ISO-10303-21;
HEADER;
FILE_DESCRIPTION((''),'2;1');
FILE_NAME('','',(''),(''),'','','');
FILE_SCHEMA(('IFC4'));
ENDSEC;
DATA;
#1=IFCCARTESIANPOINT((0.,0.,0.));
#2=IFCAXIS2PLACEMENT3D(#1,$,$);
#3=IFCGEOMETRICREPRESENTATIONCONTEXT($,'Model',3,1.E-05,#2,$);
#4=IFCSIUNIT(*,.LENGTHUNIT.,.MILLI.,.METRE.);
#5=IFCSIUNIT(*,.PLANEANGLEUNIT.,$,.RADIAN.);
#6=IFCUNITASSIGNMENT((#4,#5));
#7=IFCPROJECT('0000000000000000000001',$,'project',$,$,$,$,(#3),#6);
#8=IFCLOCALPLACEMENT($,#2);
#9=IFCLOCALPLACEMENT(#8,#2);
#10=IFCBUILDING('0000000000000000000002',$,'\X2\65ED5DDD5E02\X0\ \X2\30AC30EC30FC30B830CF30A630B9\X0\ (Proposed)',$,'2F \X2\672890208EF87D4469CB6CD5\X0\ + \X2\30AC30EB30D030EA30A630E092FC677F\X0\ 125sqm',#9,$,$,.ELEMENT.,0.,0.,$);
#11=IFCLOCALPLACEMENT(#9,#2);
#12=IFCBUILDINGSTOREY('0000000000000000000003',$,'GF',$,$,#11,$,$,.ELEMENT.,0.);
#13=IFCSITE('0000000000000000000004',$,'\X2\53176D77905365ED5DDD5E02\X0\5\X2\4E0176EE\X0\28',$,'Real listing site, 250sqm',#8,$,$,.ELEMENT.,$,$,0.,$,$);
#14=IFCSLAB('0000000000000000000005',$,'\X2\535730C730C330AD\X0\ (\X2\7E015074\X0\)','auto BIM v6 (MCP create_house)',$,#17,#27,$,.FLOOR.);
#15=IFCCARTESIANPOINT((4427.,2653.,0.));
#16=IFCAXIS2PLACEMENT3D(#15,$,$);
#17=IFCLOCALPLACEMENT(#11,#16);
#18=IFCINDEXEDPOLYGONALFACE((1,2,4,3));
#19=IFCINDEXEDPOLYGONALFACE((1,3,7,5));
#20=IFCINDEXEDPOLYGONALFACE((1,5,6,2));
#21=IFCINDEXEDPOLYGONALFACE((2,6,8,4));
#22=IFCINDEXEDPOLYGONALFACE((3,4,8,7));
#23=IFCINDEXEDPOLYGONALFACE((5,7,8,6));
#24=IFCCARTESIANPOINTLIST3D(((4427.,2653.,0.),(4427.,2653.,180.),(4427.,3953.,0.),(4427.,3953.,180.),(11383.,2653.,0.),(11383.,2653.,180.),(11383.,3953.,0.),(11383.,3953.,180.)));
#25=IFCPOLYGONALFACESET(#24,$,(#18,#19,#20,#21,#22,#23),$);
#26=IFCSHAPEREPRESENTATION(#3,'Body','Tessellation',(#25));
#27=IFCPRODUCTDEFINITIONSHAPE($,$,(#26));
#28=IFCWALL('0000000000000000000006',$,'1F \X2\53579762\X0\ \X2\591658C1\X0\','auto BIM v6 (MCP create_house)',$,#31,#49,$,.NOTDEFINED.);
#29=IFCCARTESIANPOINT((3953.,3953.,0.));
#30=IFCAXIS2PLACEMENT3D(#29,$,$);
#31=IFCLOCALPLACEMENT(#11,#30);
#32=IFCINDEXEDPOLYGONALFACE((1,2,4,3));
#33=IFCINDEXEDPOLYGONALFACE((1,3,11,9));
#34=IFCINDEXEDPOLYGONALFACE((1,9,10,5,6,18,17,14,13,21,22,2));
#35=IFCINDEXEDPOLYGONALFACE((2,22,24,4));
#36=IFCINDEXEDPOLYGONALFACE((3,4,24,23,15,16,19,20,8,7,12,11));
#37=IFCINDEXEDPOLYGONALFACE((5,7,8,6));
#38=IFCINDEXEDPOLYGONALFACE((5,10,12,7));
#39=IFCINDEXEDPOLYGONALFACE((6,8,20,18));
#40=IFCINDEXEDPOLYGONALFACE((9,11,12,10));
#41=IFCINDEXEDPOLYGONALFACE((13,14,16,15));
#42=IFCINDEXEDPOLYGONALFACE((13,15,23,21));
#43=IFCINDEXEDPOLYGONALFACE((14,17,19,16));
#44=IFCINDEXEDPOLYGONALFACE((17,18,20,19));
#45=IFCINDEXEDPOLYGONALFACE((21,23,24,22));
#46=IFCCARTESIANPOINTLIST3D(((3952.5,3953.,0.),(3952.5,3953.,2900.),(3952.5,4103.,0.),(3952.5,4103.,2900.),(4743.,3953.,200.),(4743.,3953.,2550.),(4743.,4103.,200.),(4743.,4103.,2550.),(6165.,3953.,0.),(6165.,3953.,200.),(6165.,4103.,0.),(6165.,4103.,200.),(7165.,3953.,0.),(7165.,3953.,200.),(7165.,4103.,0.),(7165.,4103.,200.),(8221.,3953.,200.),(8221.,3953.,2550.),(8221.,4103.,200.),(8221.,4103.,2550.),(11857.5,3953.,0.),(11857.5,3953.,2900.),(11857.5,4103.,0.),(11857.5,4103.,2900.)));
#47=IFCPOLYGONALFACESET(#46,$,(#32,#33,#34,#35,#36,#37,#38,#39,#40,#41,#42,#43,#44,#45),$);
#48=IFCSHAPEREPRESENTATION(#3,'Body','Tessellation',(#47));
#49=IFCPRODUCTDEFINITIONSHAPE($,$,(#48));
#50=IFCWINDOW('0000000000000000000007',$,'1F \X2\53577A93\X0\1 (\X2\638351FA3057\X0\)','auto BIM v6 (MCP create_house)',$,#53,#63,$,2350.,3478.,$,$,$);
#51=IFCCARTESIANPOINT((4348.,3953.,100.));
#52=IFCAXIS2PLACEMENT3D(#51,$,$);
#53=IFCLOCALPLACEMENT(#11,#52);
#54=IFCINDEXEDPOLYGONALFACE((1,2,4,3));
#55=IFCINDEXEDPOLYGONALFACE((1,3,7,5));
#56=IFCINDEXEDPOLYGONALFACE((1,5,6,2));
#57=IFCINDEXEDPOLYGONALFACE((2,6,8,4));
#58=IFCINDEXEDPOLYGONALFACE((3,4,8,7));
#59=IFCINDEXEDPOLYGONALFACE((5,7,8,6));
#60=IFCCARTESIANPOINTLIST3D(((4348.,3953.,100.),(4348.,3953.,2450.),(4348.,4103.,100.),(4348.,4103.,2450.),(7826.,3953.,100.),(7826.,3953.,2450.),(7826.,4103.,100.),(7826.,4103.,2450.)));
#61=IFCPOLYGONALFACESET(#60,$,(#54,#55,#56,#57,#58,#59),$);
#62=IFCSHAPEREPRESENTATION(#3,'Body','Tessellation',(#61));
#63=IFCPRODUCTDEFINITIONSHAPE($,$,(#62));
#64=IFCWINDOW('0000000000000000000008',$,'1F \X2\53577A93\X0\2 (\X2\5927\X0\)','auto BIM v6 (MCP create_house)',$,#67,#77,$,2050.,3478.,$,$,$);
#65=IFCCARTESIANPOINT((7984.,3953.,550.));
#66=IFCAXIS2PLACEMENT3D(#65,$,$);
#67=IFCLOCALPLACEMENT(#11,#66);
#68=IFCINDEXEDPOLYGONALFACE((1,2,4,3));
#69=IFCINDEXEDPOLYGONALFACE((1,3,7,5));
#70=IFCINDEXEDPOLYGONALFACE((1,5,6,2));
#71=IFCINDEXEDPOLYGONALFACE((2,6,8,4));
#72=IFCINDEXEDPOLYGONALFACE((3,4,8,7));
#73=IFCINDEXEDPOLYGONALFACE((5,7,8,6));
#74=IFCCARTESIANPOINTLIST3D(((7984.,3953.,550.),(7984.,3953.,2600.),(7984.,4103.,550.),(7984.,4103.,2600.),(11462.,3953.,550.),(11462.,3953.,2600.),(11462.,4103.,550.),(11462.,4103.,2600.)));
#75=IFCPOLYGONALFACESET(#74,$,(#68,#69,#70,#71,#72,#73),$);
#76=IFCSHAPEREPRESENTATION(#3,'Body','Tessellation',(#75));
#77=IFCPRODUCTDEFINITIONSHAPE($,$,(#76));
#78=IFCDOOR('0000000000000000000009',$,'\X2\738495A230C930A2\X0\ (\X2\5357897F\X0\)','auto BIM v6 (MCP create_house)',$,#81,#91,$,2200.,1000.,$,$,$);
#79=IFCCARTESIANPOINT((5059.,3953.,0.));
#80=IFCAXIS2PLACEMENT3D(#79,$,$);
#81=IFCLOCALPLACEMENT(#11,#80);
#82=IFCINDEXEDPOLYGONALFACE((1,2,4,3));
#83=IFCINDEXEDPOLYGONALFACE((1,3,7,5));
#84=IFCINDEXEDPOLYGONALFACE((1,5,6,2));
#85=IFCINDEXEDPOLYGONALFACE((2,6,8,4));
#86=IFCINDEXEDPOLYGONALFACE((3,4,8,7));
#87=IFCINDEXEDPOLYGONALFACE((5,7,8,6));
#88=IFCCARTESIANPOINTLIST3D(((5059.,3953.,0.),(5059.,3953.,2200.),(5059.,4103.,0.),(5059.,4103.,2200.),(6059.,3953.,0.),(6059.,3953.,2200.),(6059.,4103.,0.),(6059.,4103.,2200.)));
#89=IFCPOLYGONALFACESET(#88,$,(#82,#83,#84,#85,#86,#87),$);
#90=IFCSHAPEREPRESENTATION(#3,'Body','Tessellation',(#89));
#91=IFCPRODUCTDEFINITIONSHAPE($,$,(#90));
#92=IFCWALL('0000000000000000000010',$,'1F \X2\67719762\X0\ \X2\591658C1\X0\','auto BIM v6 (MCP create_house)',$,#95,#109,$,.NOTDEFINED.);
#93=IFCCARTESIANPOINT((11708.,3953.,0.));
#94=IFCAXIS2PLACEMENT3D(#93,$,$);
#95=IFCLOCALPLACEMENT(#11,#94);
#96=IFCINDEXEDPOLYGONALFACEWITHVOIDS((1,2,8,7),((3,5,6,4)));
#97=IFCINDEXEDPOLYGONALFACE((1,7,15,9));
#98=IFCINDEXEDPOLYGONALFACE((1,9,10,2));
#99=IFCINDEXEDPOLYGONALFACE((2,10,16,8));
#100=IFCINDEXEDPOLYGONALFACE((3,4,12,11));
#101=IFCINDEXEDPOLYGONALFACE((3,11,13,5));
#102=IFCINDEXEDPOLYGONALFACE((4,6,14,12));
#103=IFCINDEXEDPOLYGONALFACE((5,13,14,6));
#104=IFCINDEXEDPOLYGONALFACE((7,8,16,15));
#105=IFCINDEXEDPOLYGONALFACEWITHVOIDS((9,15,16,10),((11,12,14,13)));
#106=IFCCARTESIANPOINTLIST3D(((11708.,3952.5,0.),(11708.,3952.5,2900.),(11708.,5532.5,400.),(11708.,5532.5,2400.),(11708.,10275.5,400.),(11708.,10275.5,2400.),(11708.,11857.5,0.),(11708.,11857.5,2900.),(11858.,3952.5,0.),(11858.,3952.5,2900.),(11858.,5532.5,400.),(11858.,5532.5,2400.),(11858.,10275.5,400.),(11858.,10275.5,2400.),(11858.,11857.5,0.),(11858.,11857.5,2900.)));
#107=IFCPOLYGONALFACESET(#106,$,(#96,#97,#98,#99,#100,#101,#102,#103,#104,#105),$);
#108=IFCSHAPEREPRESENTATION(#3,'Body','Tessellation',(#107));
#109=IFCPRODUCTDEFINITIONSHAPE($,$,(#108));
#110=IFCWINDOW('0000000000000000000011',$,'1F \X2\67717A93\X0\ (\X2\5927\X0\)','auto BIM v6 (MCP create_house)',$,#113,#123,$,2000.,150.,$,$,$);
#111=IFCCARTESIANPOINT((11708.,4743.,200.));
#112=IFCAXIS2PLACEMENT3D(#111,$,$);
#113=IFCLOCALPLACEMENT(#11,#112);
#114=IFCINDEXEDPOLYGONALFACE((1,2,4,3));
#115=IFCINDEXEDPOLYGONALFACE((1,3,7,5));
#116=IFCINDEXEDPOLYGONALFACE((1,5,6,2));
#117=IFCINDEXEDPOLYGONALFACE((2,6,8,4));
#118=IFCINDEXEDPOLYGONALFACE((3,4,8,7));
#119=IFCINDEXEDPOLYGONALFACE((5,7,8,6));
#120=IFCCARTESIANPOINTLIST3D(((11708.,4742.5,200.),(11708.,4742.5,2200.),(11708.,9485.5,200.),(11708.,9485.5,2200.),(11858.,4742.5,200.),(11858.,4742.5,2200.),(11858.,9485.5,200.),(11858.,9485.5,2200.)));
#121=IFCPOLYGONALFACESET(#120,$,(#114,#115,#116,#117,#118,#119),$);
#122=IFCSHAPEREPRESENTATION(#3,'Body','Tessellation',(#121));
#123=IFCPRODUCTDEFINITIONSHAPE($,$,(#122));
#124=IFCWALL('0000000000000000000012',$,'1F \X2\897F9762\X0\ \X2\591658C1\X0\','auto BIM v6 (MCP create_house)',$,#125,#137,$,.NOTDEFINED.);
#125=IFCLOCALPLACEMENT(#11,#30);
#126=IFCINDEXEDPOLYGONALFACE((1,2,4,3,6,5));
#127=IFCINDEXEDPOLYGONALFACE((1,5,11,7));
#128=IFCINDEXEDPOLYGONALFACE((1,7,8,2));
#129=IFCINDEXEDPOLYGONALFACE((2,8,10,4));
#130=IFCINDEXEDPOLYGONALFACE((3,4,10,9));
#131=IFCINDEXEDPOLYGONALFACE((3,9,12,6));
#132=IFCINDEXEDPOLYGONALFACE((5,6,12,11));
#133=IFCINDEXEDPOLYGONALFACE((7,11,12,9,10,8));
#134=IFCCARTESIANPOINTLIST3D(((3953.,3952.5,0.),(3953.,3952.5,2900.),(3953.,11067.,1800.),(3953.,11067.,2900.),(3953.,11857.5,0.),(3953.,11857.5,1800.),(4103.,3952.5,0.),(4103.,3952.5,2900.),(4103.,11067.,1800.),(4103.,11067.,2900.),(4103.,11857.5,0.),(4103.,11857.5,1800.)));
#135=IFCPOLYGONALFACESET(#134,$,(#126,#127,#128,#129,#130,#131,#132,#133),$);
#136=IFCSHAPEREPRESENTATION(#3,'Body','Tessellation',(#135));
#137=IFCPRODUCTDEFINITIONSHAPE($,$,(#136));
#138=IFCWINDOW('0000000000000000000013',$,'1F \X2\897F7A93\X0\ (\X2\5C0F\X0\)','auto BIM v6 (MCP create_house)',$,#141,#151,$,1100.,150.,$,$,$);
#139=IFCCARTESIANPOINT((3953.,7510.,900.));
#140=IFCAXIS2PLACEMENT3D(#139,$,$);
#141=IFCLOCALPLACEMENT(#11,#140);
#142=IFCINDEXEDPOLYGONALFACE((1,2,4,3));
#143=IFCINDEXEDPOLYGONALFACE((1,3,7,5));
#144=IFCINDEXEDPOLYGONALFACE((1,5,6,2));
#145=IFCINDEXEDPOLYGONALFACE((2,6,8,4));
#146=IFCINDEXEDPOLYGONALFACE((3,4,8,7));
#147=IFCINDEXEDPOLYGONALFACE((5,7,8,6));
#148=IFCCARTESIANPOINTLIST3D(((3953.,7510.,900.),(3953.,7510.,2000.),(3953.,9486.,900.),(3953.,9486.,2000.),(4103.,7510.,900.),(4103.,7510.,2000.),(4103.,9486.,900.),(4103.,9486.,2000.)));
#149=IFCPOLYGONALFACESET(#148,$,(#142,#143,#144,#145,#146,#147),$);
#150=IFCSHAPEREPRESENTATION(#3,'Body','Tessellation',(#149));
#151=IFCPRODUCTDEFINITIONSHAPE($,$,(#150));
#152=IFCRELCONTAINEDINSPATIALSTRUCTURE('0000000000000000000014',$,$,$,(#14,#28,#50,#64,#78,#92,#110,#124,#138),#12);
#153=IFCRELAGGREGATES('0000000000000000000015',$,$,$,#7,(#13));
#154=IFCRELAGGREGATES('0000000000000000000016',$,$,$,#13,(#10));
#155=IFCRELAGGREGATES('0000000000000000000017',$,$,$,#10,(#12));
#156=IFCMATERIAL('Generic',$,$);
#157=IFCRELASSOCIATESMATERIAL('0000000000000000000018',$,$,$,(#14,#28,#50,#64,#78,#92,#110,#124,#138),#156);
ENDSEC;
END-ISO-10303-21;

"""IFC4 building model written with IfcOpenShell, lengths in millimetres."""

from ifc_helpers import new_model, si_unit, frame, frame_2d, origin, place, context, project, spatial, rectangle, extrude, material, element, fill, save


model = new_model("IFC4")

# Units and contexts
model_context = context("Model", 3, precision=1e-05, world=origin())
ifc_project = project(units=[si_unit("LENGTHUNIT", "METRE", prefix="MILLI"), si_unit("PLANEANGLEUNIT", "RADIAN")], contexts=[model_context])

# Site, building, storey
site_placement = place(None, origin())
site = spatial("IfcSite", under=ifc_project, at=site_placement, Name="北海道旭川市5丁目28", ObjectType="Real listing site, 250sqm", CompositionType="ELEMENT", RefElevation=0.0)
building_placement = place(site_placement, origin())
building = spatial("IfcBuilding", under=site, at=building_placement, Name="旭川市 ガレージハウス (Proposed)", ObjectType="2F 木造軸組構法 + ガルバリウム鋼板 125sqm", CompositionType="ELEMENT", ElevationOfRefHeight=0.0, ElevationOfTerrain=0.0)
storey_placement = place(building_placement, origin())
storey = spatial("IfcBuildingStorey", under=building, at=storey_placement, Name="GF", CompositionType="ELEMENT", Elevation=0.0)

# Slab
ifc_material = material(Name="Generic")
slab_1_placement = place(storey_placement, frame((4427.0, 2653.0, 0.0)))
element("IfcSlab", 1, at=slab_1_placement, inside=storey, material=ifc_material, Name="南デッキ (縁側)", Description="auto BIM v6 (MCP create_house)", PredefinedType="FLOOR", context=model_context, shape_type="SweptSolid", body=[
    extrude(rectangle(XDim=6956.0, YDim=1300.0, at=frame_2d((3478.0, 650.0))), frame((4427.0, 2653.0, 0.0)), (0.0, 0.0, 1.0), 180.0),
])

# Wall, openings, windows, door
wall_1_placement = place(storey_placement, frame((3953.0, 3953.0, 0.0)))
wall_1 = element("IfcWall", 2, at=wall_1_placement, inside=storey, material=ifc_material, Name="1F 南面 外壁", Description="auto BIM v6 (MCP create_house)", PredefinedType="NOTDEFINED", context=model_context, shape_type="SweptSolid", body=[
    extrude(rectangle(XDim=7905.0, YDim=150.0, at=frame_2d((3952.0, 75.0))), frame((3953.0, 3953.0, 0.0)), (0.0, 0.0, 1.0), 2900.0),
])
opening_1_placement = place(storey_placement, frame((4348.0, 3953.0, 100.0)))
opening_1 = element("IfcOpeningElement", 3, at=opening_1_placement, cuts=wall_1, PredefinedType="NOTDEFINED", context=model_context, shape_type="SweptSolid", body=[
    extrude(rectangle(XDim=3478.0, YDim=150.0, at=frame_2d((1739.0, 75.0))), frame((4348.0, 3953.0, 100.0)), (0.0, 0.0, 1.0), 2350.0),
])
opening_2_placement = place(storey_placement, frame((7984.0, 3953.0, 550.0)))
opening_2 = element("IfcOpeningElement", 4, at=opening_2_placement, cuts=wall_1, PredefinedType="NOTDEFINED", context=model_context, shape_type="SweptSolid", body=[
    extrude(rectangle(XDim=3478.0, YDim=150.0, at=frame_2d((1739.0, 75.0))), frame((7984.0, 3953.0, 550.0)), (0.0, 0.0, 1.0), 2050.0),
])
opening_3_placement = place(storey_placement, frame((5059.0, 3953.0, 0.0)))
opening_3 = element("IfcOpeningElement", 5, at=opening_3_placement, cuts=wall_1, PredefinedType="NOTDEFINED", context=model_context, shape_type="SweptSolid", body=[
    extrude(rectangle(XDim=1000.0, YDim=150.0, at=frame_2d((500.0, 75.0))), frame((5059.0, 3953.0, 0.0)), (0.0, 0.0, 1.0), 2200.0),
])
window_1_placement = place(storey_placement, frame((4348.0, 3953.0, 100.0)))
window_1 = element("IfcWindow", 6, at=window_1_placement, inside=storey, material=ifc_material, Name="1F 南窓1 (掃出し)", Description="auto BIM v6 (MCP create_house)", OverallHeight=2350.0, OverallWidth=3478.0, context=model_context, shape_type="SweptSolid", body=[
    extrude(rectangle(XDim=3478.0, YDim=150.0, at=frame_2d((1739.0, 75.0))), frame((4348.0, 3953.0, 100.0)), (0.0, 0.0, 1.0), 2350.0),
])
fill(opening_1, window_1)
window_2_placement = place(storey_placement, frame((7984.0, 3953.0, 550.0)))
window_2 = element("IfcWindow", 7, at=window_2_placement, inside=storey, material=ifc_material, Name="1F 南窓2 (大)", Description="auto BIM v6 (MCP create_house)", OverallHeight=2050.0, OverallWidth=3478.0, context=model_context, shape_type="SweptSolid", body=[
    extrude(rectangle(XDim=3478.0, YDim=150.0, at=frame_2d((1739.0, 75.0))), frame((7984.0, 3953.0, 550.0)), (0.0, 0.0, 1.0), 2050.0),
])
fill(opening_2, window_2)
door_placement = place(storey_placement, frame((5059.0, 3953.0, 0.0)))
door = element("IfcDoor", 8, at=door_placement, inside=storey, material=ifc_material, Name="玄関ドア (南西)", Description="auto BIM v6 (MCP create_house)", OverallHeight=2200.0, OverallWidth=1000.0, context=model_context, shape_type="SweptSolid", body=[
    extrude(rectangle(XDim=1000.0, YDim=150.0, at=frame_2d((500.0, 75.0))), frame((5059.0, 3953.0, 0.0)), (0.0, 0.0, 1.0), 2200.0),
])
fill(opening_3, door)

# Walls, openings, windows
wall_2_placement = place(storey_placement, frame((11708.0, 3953.0, 0.0)))
wall_2 = element("IfcWall", 9, at=wall_2_placement, inside=storey, material=ifc_material, Name="1F 東面 外壁", Description="auto BIM v6 (MCP create_house)", PredefinedType="NOTDEFINED", context=model_context, shape_type="SweptSolid", body=[
    extrude(rectangle(XDim=150.0, YDim=7905.0, at=frame_2d((75.0, 3952.0))), frame((11708.0, 3953.0, 0.0)), (0.0, 0.0, 1.0), 2900.0),
])
opening_4_placement = place(storey_placement, frame((11708.0, 4743.0, 200.0)))
opening_4 = element("IfcOpeningElement", 10, at=opening_4_placement, cuts=wall_2, PredefinedType="NOTDEFINED", context=model_context, shape_type="SweptSolid", body=[
    extrude(rectangle(XDim=150.0, YDim=4743.0, at=frame_2d((75.0, 2371.0))), frame((11708.0, 4743.0, 200.0)), (0.0, 0.0, 1.0), 2000.0),
])
window_3_placement = place(storey_placement, frame((11708.0, 4743.0, 200.0)))
window_3 = element("IfcWindow", 11, at=window_3_placement, inside=storey, material=ifc_material, Name="1F 東窓 (大)", Description="auto BIM v6 (MCP create_house)", OverallHeight=2000.0, OverallWidth=150.0, context=model_context, shape_type="SweptSolid", body=[
    extrude(rectangle(XDim=150.0, YDim=4743.0, at=frame_2d((75.0, 2371.0))), frame((11708.0, 4743.0, 200.0)), (0.0, 0.0, 1.0), 2000.0),
])
fill(opening_4, window_3)
wall_3_placement = place(storey_placement, frame((3953.0, 3953.0, 0.0)))
wall_3 = element("IfcWall", 12, at=wall_3_placement, inside=storey, material=ifc_material, Name="1F 西面 外壁", Description="auto BIM v6 (MCP create_house)", PredefinedType="NOTDEFINED", context=model_context, shape_type="SweptSolid", body=[
    extrude(rectangle(XDim=150.0, YDim=7905.0, at=frame_2d((75.0, 3952.0))), frame((3953.0, 3953.0, 0.0)), (0.0, 0.0, 1.0), 2900.0),
])
opening_5_placement = place(storey_placement, frame((3953.0, 7510.0, 900.0)))
opening_5 = element("IfcOpeningElement", 13, at=opening_5_placement, cuts=wall_3, PredefinedType="NOTDEFINED", context=model_context, shape_type="SweptSolid", body=[
    extrude(rectangle(XDim=150.0, YDim=1976.0, at=frame_2d((75.0, 988.0))), frame((3953.0, 7510.0, 900.0)), (0.0, 0.0, 1.0), 1100.0),
])
window_4_placement = place(storey_placement, frame((3953.0, 7510.0, 900.0)))
window_4 = element("IfcWindow", 14, at=window_4_placement, inside=storey, material=ifc_material, Name="1F 西窓 (小)", Description="auto BIM v6 (MCP create_house)", OverallHeight=1100.0, OverallWidth=150.0, context=model_context, shape_type="SweptSolid", body=[
    extrude(rectangle(XDim=150.0, YDim=1976.0, at=frame_2d((75.0, 988.0))), frame((3953.0, 7510.0, 900.0)), (0.0, 0.0, 1.0), 1100.0),
])
fill(opening_5, window_4)

save(model, "model.ifc")
